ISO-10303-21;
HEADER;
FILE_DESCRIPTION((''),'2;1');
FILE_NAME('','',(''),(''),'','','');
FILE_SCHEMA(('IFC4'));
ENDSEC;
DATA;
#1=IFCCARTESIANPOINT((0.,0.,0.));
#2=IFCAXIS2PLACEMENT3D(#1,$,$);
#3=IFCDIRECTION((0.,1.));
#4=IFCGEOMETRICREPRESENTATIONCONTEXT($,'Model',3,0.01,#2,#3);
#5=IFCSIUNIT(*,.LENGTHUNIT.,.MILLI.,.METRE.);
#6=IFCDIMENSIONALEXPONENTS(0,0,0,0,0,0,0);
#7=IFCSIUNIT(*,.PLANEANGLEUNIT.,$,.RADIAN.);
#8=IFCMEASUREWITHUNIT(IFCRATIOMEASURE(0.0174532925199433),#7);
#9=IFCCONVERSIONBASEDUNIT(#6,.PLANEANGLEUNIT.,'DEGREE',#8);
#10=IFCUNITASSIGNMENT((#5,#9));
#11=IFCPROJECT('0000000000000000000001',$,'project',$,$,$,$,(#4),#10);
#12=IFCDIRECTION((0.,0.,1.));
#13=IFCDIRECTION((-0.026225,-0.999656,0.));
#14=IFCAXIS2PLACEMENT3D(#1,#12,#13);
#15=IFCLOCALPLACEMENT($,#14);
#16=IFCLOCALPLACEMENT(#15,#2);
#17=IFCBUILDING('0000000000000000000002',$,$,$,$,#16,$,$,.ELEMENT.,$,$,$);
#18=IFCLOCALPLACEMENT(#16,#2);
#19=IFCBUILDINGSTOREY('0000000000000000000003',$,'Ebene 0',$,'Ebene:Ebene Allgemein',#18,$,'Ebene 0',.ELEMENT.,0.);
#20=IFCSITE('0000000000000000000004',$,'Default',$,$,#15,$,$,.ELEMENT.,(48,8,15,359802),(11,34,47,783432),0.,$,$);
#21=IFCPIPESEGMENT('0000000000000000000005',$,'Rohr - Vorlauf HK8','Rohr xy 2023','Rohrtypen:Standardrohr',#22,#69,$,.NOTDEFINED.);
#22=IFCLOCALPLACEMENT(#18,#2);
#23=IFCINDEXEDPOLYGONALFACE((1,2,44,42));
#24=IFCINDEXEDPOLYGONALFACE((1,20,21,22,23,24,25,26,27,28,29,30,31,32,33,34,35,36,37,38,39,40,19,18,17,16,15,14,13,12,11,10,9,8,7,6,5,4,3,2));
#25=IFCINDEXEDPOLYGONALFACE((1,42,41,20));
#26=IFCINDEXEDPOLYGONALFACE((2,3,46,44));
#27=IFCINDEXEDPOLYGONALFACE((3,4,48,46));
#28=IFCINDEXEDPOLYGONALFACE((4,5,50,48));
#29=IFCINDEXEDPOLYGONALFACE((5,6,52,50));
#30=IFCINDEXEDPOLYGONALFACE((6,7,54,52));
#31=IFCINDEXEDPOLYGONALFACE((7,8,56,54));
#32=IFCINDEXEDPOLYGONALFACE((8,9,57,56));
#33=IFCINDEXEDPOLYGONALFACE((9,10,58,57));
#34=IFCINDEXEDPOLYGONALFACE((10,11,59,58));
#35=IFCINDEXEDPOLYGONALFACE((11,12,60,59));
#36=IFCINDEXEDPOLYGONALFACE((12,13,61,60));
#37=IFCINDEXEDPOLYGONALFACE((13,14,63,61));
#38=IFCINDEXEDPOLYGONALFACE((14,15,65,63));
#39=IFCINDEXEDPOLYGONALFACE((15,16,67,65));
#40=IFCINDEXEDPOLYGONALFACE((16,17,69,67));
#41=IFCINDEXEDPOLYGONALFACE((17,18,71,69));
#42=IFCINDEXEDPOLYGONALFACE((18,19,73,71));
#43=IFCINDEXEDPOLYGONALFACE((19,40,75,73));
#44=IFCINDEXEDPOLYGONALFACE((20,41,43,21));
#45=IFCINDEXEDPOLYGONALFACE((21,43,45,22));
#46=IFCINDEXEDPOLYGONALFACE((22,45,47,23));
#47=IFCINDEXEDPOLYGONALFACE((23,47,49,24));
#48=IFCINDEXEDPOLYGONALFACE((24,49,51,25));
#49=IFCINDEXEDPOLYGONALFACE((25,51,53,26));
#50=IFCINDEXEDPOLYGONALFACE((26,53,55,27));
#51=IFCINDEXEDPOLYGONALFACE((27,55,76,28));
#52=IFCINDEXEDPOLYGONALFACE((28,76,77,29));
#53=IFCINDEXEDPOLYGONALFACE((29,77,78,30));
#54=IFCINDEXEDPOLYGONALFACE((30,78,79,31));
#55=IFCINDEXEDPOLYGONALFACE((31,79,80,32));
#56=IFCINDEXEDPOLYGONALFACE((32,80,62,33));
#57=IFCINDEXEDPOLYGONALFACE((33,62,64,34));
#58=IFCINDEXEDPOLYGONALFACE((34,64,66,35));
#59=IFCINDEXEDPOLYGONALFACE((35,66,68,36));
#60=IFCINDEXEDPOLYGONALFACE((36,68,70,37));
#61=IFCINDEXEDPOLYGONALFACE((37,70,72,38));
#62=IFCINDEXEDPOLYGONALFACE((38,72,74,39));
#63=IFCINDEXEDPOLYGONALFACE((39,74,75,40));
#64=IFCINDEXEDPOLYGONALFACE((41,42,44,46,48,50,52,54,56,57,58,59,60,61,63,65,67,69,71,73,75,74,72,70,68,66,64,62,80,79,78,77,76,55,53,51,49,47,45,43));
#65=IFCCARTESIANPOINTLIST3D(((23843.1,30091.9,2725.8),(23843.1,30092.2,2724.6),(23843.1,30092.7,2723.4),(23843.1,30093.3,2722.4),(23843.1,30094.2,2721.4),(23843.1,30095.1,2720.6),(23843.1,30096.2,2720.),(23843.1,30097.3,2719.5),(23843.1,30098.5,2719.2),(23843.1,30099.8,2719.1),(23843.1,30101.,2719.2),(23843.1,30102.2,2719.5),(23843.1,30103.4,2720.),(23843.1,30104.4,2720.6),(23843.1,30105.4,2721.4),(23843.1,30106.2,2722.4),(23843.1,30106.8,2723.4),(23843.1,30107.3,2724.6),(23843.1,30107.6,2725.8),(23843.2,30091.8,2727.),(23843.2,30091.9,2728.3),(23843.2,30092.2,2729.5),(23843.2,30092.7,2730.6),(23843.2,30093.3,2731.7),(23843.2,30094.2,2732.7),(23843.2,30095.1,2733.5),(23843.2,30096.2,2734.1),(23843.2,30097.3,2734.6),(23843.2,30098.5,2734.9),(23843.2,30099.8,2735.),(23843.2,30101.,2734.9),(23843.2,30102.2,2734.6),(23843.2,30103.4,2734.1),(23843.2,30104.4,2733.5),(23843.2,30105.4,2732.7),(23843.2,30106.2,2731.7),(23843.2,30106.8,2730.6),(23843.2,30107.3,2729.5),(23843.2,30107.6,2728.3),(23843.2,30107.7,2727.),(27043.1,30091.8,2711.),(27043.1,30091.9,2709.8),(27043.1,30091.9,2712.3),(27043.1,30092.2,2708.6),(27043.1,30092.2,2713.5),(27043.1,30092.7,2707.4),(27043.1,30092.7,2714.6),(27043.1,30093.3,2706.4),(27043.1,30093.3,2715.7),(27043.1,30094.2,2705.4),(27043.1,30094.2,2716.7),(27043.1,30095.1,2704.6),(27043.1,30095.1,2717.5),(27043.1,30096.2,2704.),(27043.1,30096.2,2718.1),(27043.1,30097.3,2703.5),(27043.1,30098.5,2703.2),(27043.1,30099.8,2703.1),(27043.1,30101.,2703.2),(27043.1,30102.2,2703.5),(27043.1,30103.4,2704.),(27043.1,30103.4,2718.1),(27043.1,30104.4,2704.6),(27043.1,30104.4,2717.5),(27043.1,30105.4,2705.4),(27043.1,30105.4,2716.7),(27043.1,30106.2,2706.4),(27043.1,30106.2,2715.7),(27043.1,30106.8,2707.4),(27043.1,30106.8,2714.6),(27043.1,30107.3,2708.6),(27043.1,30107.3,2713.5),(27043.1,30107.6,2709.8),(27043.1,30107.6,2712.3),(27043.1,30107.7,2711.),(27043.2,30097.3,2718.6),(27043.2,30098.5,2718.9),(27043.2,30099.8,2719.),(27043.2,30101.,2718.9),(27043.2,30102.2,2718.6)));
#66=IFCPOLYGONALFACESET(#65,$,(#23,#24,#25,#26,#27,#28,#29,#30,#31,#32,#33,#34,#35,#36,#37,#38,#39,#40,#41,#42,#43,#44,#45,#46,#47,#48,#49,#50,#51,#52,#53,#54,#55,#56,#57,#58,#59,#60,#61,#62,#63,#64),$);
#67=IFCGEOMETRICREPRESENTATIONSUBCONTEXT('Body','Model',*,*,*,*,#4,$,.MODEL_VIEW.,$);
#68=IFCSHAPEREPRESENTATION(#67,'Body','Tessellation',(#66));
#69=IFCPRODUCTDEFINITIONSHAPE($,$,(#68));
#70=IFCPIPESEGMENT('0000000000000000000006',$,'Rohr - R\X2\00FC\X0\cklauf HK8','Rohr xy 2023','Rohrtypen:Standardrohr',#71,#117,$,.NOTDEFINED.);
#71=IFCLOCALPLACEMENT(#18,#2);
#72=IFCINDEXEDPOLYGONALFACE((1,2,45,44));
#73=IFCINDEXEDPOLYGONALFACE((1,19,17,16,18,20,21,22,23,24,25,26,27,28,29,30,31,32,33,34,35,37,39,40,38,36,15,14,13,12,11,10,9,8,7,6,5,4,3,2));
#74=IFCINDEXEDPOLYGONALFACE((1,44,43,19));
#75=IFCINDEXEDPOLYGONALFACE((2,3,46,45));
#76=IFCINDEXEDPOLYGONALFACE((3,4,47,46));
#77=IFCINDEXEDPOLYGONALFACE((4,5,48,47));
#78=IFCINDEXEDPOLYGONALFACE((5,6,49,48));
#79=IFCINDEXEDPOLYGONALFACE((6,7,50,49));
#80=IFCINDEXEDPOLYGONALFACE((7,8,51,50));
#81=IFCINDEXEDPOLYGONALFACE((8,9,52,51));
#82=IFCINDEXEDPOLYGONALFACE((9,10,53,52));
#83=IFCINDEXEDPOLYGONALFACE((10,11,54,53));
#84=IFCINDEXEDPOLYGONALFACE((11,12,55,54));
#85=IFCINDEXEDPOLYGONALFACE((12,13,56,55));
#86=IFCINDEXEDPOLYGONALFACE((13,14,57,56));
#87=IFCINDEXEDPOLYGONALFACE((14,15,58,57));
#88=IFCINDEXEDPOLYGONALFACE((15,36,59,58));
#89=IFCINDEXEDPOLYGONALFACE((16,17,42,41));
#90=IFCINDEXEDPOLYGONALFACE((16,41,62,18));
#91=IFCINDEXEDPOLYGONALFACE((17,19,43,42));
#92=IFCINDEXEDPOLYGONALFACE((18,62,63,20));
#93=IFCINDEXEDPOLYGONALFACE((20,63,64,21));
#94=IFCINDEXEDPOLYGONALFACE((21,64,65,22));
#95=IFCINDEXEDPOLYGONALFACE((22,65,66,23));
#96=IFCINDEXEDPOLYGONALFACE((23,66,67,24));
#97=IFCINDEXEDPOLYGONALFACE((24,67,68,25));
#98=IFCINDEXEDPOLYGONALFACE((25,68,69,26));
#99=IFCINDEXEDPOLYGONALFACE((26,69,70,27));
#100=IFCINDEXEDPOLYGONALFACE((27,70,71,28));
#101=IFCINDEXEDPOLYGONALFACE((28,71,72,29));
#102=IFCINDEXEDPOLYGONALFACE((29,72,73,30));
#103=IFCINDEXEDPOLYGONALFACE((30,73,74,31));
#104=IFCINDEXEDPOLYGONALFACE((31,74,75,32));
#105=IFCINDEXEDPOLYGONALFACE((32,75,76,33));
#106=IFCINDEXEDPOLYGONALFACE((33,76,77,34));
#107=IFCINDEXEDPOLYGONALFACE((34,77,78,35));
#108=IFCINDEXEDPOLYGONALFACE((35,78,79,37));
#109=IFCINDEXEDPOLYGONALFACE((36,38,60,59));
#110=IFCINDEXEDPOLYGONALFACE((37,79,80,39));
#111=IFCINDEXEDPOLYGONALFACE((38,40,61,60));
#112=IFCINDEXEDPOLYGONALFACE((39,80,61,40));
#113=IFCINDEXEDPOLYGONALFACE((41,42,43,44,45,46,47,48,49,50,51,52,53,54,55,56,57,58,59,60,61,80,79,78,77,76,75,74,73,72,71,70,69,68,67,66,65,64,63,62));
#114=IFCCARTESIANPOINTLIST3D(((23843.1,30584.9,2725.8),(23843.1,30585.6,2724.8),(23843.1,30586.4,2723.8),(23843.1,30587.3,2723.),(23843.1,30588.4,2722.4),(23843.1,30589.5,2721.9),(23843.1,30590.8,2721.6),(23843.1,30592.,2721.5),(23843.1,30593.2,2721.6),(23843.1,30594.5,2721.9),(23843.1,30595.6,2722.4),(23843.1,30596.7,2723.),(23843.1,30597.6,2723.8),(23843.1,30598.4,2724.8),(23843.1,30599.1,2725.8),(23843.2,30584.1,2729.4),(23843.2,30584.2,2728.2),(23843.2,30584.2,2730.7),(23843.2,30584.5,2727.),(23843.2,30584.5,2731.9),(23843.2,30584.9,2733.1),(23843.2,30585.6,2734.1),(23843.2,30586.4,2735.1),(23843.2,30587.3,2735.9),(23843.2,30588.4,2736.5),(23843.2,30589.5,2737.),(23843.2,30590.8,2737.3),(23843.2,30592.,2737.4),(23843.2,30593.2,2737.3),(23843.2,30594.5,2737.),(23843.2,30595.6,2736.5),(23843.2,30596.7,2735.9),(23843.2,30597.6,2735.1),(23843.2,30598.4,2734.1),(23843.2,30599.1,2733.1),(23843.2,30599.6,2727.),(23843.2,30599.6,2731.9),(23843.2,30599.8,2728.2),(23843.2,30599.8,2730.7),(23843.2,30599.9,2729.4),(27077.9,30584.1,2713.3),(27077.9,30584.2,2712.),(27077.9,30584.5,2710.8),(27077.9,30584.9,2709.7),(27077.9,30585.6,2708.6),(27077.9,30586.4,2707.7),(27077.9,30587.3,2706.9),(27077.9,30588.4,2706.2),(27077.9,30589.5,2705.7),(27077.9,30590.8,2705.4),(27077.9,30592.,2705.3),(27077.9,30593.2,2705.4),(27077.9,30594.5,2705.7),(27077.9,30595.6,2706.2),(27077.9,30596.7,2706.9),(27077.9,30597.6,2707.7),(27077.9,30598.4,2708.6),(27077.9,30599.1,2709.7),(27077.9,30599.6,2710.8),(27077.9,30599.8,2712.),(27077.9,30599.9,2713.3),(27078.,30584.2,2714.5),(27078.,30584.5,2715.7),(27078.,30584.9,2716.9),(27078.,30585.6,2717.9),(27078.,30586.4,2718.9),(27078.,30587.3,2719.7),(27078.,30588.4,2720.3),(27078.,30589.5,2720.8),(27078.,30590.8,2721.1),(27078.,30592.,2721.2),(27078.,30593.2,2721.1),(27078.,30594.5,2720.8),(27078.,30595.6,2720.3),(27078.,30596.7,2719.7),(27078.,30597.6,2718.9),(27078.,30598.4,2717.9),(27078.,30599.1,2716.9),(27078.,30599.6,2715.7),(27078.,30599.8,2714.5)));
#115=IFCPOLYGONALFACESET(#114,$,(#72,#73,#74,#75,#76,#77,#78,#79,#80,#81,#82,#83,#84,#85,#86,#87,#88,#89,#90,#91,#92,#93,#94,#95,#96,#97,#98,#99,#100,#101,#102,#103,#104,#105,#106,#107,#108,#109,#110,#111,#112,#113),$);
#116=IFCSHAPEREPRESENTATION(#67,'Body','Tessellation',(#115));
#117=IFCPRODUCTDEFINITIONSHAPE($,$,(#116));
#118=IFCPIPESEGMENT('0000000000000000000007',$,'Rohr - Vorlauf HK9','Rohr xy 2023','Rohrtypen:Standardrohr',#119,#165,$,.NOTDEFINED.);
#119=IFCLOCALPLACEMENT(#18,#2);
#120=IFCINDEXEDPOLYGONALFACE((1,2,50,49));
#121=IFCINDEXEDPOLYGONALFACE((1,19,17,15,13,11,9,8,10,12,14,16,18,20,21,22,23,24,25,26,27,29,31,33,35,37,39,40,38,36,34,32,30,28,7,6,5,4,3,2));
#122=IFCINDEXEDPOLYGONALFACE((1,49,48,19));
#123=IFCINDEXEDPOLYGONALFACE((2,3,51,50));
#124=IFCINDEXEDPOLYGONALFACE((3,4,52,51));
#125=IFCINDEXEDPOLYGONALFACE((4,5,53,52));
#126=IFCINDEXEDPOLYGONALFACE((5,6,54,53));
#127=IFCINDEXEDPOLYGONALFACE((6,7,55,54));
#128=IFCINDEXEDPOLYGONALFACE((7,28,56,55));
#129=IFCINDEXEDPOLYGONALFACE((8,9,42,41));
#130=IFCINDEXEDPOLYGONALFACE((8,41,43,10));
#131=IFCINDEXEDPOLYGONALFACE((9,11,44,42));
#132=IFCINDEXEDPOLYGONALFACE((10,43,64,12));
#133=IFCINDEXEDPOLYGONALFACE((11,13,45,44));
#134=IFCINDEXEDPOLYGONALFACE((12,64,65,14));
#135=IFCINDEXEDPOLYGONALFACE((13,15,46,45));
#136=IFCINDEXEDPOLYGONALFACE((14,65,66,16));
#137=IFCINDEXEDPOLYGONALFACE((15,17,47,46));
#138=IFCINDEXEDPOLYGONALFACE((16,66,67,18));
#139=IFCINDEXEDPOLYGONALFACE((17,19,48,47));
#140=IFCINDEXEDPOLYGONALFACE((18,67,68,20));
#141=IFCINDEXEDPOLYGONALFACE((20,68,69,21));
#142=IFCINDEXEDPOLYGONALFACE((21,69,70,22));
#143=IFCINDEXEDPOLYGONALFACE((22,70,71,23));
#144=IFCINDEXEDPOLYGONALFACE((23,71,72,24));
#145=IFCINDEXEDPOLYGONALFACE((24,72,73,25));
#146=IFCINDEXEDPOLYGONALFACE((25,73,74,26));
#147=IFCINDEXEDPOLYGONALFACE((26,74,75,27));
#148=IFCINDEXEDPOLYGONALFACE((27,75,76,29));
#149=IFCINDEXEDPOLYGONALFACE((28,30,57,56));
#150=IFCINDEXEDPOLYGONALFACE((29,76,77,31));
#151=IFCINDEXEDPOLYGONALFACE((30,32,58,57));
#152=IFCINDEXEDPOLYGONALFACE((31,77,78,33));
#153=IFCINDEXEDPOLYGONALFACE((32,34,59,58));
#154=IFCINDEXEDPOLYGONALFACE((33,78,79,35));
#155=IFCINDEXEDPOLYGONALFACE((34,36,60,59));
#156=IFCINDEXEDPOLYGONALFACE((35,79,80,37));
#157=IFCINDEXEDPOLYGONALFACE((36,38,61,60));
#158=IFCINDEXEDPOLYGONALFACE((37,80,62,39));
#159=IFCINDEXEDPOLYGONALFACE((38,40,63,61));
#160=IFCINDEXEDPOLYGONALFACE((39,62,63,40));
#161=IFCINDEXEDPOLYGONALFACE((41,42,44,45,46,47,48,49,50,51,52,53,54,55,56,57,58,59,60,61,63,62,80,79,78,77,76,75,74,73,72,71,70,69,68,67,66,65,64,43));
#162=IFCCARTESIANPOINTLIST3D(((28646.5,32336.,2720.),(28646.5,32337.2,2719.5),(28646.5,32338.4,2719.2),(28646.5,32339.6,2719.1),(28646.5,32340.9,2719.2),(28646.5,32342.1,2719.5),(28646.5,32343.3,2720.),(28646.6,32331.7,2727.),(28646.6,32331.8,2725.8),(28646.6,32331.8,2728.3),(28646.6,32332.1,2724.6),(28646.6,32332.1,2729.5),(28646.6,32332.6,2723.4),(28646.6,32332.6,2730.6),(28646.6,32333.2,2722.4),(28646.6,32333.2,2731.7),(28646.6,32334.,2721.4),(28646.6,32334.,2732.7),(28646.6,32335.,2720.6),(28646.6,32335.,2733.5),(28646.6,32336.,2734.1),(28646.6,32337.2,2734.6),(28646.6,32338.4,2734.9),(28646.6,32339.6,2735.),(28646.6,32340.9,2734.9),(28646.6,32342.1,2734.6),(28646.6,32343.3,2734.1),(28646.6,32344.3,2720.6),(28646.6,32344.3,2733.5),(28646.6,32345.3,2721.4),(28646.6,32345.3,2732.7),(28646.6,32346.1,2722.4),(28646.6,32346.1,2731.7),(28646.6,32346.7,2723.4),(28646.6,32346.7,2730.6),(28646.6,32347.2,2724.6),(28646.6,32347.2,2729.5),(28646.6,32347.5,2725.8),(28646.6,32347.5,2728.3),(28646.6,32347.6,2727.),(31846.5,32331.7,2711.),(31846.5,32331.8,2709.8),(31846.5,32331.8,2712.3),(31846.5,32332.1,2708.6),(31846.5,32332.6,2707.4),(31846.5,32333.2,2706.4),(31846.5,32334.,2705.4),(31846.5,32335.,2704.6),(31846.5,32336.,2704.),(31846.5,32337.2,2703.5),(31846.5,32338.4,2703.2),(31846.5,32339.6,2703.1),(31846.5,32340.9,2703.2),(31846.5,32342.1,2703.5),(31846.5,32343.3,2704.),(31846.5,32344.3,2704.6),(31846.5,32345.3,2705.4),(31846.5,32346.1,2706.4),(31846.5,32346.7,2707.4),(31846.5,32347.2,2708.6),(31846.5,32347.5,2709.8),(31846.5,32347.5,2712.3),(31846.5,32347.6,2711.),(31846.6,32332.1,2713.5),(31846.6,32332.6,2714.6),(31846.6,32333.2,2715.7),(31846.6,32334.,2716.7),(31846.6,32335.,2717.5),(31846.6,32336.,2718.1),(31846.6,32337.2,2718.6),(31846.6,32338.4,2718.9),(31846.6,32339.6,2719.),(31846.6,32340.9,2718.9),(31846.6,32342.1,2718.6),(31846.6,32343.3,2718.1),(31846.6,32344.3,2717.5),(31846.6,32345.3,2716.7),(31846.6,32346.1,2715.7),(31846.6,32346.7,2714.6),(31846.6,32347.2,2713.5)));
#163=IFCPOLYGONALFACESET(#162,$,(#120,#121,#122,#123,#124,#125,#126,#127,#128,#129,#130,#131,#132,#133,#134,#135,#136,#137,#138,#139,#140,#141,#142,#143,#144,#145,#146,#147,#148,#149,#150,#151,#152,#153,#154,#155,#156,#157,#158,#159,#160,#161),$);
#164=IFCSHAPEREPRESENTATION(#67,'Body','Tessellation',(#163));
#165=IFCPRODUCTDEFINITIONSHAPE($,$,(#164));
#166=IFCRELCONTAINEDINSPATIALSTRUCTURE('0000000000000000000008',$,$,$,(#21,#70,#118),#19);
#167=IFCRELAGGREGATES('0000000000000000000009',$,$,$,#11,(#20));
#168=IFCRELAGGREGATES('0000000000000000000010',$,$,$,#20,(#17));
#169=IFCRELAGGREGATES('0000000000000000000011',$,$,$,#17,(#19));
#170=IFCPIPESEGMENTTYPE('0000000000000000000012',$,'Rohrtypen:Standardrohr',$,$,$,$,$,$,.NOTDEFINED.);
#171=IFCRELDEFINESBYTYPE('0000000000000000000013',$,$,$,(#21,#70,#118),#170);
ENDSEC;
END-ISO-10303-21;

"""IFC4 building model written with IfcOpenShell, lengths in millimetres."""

from ifc_helpers import new_model, entity, si_unit, converted_unit, direction, frame, origin, place, context, subcontext, project, spatial, indexed_curve, outline, extrude, type_object, element, save


model = new_model("IFC4")

# Units and contexts
model_context = context("Model", 3, precision=0.01, world=origin(), true_north=direction((0.0, 1.0)))
body_context = subcontext(model_context, "Body", "Model", "MODEL_VIEW")
ifc_project = project(units=[si_unit("LENGTHUNIT", "METRE", prefix="MILLI"), converted_unit("PLANEANGLEUNIT", "DEGREE", entity("IfcRatioMeasure", 0.0174532925199433), si_unit("PLANEANGLEUNIT", "RADIAN"), dimensions=[0, 0, 0, 0, 0, 0, 0])], contexts=[model_context])

# Site, building, storey
site_placement = place(None, frame((0.0, 0.0, 0.0), z_axis=(0.0, 0.0, 1.0), x_axis=(-0.026225, -0.999656, 0.0)))
site = spatial("IfcSite", under=ifc_project, at=site_placement, Name="Default", CompositionType="ELEMENT", RefLatitude=(48, 8, 15, 359802), RefLongitude=(11, 34, 47, 783432), RefElevation=0.0)
building_placement = place(site_placement, origin())
building = spatial("IfcBuilding", under=site, at=building_placement, CompositionType="ELEMENT")
storey_placement = place(building_placement, origin())
storey = spatial("IfcBuildingStorey", under=building, at=storey_placement, Name="Ebene 0", ObjectType="Ebene:Ebene Allgemein", LongName="Ebene 0", CompositionType="ELEMENT", Elevation=0.0)

# Pipe segments
pipe_segment_type = type_object("IfcPipeSegmentType", Name="Rohrtypen:Standardrohr", PredefinedType="NOTDEFINED")
pipe_segment_1_placement = place(storey_placement, origin())
element("IfcPipeSegment", 1, at=pipe_segment_1_placement, inside=storey, type_object=pipe_segment_type, Name="Rohr - Vorlauf HK8", Description="Rohr xy 2023", ObjectType="Rohrtypen:Standardrohr", PredefinedType="NOTDEFINED", context=body_context, shape_type="SweptSolid", body=[
    extrude(outline(indexed_curve([(7.9, 0.0), (7.8, 1.2), (7.6, 2.5), (7.1, 3.6), (6.4, 4.7), (5.6, 5.6), (4.7, 6.4), (3.6, 7.1), (2.5, 7.6), (1.2, 7.8), (0.0, 7.9), (-1.2, 7.8), (-2.5, 7.6), (-3.6, 7.1), (-4.7, 6.4), (-5.6, 5.6), (-6.4, 4.7), (-7.1, 3.6), (-7.6, 2.5), (-7.8, 1.2), (-7.9, 0.0), (-7.8, -1.2), (-7.6, -2.5), (-7.1, -3.6), (-6.4, -4.7), (-5.6, -5.6), (-4.7, -6.4), (-3.6, -7.1), (-2.5, -7.6), (-1.2, -7.8), (0.0, -7.9), (1.2, -7.8), (2.5, -7.6), (3.6, -7.1), (4.7, -6.4), (5.6, -5.6), (6.4, -4.7), (7.1, -3.6), (7.6, -2.5), (7.8, -1.2), (7.9, 0.0)], self_intersect=False)), frame((27043.1, 30099.8, 2711.0), z_axis=(-0.999988, 0.0, 0.005), x_axis=(0.0, 1.0, 0.0)), (0.0, 0.0, 1.0), 3200.0),
])
pipe_segment_2_placement = place(storey_placement, origin())
element("IfcPipeSegment", 2, at=pipe_segment_2_placement, inside=storey, type_object=pipe_segment_type, Name="Rohr - Rücklauf HK8", Description="Rohr xy 2023", ObjectType="Rohrtypen:Standardrohr", PredefinedType="NOTDEFINED", context=body_context, shape_type="SweptSolid", body=[
    extrude(outline(indexed_curve([(7.9, 0.0), (7.8, 1.2), (7.6, 2.5), (7.1, 3.6), (6.4, 4.7), (5.6, 5.6), (4.7, 6.4), (3.6, 7.1), (2.5, 7.6), (1.2, 7.8), (0.0, 7.9), (-1.2, 7.8), (-2.5, 7.6), (-3.6, 7.1), (-4.7, 6.4), (-5.6, 5.6), (-6.4, 4.7), (-7.1, 3.6), (-7.6, 2.5), (-7.8, 1.2), (-7.9, 0.0), (-7.8, -1.2), (-7.6, -2.5), (-7.1, -3.6), (-6.4, -4.7), (-5.6, -5.6), (-4.7, -6.4), (-3.6, -7.1), (-2.5, -7.6), (-1.2, -7.8), (0.0, -7.9), (1.2, -7.8), (2.5, -7.6), (3.6, -7.1), (4.7, -6.4), (5.6, -5.6), (6.4, -4.7), (7.1, -3.6), (7.6, -2.5), (7.8, -1.2), (7.9, 0.0)], self_intersect=False)), frame((27077.9, 30592.0, 2713.3), z_axis=(-0.999988, 0.0, 0.005), x_axis=(0.0, 1.0, 0.0)), (0.0, 0.0, 1.0), 3234.8),
])
pipe_segment_3_placement = place(storey_placement, origin())
element("IfcPipeSegment", 3, at=pipe_segment_3_placement, inside=storey, type_object=pipe_segment_type, Name="Rohr - Vorlauf HK9", Description="Rohr xy 2023", ObjectType="Rohrtypen:Standardrohr", PredefinedType="NOTDEFINED", context=body_context, shape_type="SweptSolid", body=[
    extrude(outline(indexed_curve([(7.9, 0.0), (7.8, 1.2), (7.6, 2.5), (7.1, 3.6), (6.4, 4.7), (5.6, 5.6), (4.7, 6.4), (3.6, 7.1), (2.5, 7.6), (1.2, 7.8), (0.0, 7.9), (-1.2, 7.8), (-2.5, 7.6), (-3.6, 7.1), (-4.7, 6.4), (-5.6, 5.6), (-6.4, 4.7), (-7.1, 3.6), (-7.6, 2.5), (-7.8, 1.2), (-7.9, 0.0), (-7.8, -1.2), (-7.6, -2.5), (-7.1, -3.6), (-6.4, -4.7), (-5.6, -5.6), (-4.7, -6.4), (-3.6, -7.1), (-2.5, -7.6), (-1.2, -7.8), (0.0, -7.9), (1.2, -7.8), (2.5, -7.6), (3.6, -7.1), (4.7, -6.4), (5.6, -5.6), (6.4, -4.7), (7.1, -3.6), (7.6, -2.5), (7.8, -1.2), (7.9, 0.0)], self_intersect=False)), frame((31846.5, 32339.6, 2711.0), z_axis=(-0.999988, 0.0, 0.005), x_axis=(0.0, 1.0, 0.0)), (0.0, 0.0, 1.0), 3200.0),
])

save(model, "model.ifc")
